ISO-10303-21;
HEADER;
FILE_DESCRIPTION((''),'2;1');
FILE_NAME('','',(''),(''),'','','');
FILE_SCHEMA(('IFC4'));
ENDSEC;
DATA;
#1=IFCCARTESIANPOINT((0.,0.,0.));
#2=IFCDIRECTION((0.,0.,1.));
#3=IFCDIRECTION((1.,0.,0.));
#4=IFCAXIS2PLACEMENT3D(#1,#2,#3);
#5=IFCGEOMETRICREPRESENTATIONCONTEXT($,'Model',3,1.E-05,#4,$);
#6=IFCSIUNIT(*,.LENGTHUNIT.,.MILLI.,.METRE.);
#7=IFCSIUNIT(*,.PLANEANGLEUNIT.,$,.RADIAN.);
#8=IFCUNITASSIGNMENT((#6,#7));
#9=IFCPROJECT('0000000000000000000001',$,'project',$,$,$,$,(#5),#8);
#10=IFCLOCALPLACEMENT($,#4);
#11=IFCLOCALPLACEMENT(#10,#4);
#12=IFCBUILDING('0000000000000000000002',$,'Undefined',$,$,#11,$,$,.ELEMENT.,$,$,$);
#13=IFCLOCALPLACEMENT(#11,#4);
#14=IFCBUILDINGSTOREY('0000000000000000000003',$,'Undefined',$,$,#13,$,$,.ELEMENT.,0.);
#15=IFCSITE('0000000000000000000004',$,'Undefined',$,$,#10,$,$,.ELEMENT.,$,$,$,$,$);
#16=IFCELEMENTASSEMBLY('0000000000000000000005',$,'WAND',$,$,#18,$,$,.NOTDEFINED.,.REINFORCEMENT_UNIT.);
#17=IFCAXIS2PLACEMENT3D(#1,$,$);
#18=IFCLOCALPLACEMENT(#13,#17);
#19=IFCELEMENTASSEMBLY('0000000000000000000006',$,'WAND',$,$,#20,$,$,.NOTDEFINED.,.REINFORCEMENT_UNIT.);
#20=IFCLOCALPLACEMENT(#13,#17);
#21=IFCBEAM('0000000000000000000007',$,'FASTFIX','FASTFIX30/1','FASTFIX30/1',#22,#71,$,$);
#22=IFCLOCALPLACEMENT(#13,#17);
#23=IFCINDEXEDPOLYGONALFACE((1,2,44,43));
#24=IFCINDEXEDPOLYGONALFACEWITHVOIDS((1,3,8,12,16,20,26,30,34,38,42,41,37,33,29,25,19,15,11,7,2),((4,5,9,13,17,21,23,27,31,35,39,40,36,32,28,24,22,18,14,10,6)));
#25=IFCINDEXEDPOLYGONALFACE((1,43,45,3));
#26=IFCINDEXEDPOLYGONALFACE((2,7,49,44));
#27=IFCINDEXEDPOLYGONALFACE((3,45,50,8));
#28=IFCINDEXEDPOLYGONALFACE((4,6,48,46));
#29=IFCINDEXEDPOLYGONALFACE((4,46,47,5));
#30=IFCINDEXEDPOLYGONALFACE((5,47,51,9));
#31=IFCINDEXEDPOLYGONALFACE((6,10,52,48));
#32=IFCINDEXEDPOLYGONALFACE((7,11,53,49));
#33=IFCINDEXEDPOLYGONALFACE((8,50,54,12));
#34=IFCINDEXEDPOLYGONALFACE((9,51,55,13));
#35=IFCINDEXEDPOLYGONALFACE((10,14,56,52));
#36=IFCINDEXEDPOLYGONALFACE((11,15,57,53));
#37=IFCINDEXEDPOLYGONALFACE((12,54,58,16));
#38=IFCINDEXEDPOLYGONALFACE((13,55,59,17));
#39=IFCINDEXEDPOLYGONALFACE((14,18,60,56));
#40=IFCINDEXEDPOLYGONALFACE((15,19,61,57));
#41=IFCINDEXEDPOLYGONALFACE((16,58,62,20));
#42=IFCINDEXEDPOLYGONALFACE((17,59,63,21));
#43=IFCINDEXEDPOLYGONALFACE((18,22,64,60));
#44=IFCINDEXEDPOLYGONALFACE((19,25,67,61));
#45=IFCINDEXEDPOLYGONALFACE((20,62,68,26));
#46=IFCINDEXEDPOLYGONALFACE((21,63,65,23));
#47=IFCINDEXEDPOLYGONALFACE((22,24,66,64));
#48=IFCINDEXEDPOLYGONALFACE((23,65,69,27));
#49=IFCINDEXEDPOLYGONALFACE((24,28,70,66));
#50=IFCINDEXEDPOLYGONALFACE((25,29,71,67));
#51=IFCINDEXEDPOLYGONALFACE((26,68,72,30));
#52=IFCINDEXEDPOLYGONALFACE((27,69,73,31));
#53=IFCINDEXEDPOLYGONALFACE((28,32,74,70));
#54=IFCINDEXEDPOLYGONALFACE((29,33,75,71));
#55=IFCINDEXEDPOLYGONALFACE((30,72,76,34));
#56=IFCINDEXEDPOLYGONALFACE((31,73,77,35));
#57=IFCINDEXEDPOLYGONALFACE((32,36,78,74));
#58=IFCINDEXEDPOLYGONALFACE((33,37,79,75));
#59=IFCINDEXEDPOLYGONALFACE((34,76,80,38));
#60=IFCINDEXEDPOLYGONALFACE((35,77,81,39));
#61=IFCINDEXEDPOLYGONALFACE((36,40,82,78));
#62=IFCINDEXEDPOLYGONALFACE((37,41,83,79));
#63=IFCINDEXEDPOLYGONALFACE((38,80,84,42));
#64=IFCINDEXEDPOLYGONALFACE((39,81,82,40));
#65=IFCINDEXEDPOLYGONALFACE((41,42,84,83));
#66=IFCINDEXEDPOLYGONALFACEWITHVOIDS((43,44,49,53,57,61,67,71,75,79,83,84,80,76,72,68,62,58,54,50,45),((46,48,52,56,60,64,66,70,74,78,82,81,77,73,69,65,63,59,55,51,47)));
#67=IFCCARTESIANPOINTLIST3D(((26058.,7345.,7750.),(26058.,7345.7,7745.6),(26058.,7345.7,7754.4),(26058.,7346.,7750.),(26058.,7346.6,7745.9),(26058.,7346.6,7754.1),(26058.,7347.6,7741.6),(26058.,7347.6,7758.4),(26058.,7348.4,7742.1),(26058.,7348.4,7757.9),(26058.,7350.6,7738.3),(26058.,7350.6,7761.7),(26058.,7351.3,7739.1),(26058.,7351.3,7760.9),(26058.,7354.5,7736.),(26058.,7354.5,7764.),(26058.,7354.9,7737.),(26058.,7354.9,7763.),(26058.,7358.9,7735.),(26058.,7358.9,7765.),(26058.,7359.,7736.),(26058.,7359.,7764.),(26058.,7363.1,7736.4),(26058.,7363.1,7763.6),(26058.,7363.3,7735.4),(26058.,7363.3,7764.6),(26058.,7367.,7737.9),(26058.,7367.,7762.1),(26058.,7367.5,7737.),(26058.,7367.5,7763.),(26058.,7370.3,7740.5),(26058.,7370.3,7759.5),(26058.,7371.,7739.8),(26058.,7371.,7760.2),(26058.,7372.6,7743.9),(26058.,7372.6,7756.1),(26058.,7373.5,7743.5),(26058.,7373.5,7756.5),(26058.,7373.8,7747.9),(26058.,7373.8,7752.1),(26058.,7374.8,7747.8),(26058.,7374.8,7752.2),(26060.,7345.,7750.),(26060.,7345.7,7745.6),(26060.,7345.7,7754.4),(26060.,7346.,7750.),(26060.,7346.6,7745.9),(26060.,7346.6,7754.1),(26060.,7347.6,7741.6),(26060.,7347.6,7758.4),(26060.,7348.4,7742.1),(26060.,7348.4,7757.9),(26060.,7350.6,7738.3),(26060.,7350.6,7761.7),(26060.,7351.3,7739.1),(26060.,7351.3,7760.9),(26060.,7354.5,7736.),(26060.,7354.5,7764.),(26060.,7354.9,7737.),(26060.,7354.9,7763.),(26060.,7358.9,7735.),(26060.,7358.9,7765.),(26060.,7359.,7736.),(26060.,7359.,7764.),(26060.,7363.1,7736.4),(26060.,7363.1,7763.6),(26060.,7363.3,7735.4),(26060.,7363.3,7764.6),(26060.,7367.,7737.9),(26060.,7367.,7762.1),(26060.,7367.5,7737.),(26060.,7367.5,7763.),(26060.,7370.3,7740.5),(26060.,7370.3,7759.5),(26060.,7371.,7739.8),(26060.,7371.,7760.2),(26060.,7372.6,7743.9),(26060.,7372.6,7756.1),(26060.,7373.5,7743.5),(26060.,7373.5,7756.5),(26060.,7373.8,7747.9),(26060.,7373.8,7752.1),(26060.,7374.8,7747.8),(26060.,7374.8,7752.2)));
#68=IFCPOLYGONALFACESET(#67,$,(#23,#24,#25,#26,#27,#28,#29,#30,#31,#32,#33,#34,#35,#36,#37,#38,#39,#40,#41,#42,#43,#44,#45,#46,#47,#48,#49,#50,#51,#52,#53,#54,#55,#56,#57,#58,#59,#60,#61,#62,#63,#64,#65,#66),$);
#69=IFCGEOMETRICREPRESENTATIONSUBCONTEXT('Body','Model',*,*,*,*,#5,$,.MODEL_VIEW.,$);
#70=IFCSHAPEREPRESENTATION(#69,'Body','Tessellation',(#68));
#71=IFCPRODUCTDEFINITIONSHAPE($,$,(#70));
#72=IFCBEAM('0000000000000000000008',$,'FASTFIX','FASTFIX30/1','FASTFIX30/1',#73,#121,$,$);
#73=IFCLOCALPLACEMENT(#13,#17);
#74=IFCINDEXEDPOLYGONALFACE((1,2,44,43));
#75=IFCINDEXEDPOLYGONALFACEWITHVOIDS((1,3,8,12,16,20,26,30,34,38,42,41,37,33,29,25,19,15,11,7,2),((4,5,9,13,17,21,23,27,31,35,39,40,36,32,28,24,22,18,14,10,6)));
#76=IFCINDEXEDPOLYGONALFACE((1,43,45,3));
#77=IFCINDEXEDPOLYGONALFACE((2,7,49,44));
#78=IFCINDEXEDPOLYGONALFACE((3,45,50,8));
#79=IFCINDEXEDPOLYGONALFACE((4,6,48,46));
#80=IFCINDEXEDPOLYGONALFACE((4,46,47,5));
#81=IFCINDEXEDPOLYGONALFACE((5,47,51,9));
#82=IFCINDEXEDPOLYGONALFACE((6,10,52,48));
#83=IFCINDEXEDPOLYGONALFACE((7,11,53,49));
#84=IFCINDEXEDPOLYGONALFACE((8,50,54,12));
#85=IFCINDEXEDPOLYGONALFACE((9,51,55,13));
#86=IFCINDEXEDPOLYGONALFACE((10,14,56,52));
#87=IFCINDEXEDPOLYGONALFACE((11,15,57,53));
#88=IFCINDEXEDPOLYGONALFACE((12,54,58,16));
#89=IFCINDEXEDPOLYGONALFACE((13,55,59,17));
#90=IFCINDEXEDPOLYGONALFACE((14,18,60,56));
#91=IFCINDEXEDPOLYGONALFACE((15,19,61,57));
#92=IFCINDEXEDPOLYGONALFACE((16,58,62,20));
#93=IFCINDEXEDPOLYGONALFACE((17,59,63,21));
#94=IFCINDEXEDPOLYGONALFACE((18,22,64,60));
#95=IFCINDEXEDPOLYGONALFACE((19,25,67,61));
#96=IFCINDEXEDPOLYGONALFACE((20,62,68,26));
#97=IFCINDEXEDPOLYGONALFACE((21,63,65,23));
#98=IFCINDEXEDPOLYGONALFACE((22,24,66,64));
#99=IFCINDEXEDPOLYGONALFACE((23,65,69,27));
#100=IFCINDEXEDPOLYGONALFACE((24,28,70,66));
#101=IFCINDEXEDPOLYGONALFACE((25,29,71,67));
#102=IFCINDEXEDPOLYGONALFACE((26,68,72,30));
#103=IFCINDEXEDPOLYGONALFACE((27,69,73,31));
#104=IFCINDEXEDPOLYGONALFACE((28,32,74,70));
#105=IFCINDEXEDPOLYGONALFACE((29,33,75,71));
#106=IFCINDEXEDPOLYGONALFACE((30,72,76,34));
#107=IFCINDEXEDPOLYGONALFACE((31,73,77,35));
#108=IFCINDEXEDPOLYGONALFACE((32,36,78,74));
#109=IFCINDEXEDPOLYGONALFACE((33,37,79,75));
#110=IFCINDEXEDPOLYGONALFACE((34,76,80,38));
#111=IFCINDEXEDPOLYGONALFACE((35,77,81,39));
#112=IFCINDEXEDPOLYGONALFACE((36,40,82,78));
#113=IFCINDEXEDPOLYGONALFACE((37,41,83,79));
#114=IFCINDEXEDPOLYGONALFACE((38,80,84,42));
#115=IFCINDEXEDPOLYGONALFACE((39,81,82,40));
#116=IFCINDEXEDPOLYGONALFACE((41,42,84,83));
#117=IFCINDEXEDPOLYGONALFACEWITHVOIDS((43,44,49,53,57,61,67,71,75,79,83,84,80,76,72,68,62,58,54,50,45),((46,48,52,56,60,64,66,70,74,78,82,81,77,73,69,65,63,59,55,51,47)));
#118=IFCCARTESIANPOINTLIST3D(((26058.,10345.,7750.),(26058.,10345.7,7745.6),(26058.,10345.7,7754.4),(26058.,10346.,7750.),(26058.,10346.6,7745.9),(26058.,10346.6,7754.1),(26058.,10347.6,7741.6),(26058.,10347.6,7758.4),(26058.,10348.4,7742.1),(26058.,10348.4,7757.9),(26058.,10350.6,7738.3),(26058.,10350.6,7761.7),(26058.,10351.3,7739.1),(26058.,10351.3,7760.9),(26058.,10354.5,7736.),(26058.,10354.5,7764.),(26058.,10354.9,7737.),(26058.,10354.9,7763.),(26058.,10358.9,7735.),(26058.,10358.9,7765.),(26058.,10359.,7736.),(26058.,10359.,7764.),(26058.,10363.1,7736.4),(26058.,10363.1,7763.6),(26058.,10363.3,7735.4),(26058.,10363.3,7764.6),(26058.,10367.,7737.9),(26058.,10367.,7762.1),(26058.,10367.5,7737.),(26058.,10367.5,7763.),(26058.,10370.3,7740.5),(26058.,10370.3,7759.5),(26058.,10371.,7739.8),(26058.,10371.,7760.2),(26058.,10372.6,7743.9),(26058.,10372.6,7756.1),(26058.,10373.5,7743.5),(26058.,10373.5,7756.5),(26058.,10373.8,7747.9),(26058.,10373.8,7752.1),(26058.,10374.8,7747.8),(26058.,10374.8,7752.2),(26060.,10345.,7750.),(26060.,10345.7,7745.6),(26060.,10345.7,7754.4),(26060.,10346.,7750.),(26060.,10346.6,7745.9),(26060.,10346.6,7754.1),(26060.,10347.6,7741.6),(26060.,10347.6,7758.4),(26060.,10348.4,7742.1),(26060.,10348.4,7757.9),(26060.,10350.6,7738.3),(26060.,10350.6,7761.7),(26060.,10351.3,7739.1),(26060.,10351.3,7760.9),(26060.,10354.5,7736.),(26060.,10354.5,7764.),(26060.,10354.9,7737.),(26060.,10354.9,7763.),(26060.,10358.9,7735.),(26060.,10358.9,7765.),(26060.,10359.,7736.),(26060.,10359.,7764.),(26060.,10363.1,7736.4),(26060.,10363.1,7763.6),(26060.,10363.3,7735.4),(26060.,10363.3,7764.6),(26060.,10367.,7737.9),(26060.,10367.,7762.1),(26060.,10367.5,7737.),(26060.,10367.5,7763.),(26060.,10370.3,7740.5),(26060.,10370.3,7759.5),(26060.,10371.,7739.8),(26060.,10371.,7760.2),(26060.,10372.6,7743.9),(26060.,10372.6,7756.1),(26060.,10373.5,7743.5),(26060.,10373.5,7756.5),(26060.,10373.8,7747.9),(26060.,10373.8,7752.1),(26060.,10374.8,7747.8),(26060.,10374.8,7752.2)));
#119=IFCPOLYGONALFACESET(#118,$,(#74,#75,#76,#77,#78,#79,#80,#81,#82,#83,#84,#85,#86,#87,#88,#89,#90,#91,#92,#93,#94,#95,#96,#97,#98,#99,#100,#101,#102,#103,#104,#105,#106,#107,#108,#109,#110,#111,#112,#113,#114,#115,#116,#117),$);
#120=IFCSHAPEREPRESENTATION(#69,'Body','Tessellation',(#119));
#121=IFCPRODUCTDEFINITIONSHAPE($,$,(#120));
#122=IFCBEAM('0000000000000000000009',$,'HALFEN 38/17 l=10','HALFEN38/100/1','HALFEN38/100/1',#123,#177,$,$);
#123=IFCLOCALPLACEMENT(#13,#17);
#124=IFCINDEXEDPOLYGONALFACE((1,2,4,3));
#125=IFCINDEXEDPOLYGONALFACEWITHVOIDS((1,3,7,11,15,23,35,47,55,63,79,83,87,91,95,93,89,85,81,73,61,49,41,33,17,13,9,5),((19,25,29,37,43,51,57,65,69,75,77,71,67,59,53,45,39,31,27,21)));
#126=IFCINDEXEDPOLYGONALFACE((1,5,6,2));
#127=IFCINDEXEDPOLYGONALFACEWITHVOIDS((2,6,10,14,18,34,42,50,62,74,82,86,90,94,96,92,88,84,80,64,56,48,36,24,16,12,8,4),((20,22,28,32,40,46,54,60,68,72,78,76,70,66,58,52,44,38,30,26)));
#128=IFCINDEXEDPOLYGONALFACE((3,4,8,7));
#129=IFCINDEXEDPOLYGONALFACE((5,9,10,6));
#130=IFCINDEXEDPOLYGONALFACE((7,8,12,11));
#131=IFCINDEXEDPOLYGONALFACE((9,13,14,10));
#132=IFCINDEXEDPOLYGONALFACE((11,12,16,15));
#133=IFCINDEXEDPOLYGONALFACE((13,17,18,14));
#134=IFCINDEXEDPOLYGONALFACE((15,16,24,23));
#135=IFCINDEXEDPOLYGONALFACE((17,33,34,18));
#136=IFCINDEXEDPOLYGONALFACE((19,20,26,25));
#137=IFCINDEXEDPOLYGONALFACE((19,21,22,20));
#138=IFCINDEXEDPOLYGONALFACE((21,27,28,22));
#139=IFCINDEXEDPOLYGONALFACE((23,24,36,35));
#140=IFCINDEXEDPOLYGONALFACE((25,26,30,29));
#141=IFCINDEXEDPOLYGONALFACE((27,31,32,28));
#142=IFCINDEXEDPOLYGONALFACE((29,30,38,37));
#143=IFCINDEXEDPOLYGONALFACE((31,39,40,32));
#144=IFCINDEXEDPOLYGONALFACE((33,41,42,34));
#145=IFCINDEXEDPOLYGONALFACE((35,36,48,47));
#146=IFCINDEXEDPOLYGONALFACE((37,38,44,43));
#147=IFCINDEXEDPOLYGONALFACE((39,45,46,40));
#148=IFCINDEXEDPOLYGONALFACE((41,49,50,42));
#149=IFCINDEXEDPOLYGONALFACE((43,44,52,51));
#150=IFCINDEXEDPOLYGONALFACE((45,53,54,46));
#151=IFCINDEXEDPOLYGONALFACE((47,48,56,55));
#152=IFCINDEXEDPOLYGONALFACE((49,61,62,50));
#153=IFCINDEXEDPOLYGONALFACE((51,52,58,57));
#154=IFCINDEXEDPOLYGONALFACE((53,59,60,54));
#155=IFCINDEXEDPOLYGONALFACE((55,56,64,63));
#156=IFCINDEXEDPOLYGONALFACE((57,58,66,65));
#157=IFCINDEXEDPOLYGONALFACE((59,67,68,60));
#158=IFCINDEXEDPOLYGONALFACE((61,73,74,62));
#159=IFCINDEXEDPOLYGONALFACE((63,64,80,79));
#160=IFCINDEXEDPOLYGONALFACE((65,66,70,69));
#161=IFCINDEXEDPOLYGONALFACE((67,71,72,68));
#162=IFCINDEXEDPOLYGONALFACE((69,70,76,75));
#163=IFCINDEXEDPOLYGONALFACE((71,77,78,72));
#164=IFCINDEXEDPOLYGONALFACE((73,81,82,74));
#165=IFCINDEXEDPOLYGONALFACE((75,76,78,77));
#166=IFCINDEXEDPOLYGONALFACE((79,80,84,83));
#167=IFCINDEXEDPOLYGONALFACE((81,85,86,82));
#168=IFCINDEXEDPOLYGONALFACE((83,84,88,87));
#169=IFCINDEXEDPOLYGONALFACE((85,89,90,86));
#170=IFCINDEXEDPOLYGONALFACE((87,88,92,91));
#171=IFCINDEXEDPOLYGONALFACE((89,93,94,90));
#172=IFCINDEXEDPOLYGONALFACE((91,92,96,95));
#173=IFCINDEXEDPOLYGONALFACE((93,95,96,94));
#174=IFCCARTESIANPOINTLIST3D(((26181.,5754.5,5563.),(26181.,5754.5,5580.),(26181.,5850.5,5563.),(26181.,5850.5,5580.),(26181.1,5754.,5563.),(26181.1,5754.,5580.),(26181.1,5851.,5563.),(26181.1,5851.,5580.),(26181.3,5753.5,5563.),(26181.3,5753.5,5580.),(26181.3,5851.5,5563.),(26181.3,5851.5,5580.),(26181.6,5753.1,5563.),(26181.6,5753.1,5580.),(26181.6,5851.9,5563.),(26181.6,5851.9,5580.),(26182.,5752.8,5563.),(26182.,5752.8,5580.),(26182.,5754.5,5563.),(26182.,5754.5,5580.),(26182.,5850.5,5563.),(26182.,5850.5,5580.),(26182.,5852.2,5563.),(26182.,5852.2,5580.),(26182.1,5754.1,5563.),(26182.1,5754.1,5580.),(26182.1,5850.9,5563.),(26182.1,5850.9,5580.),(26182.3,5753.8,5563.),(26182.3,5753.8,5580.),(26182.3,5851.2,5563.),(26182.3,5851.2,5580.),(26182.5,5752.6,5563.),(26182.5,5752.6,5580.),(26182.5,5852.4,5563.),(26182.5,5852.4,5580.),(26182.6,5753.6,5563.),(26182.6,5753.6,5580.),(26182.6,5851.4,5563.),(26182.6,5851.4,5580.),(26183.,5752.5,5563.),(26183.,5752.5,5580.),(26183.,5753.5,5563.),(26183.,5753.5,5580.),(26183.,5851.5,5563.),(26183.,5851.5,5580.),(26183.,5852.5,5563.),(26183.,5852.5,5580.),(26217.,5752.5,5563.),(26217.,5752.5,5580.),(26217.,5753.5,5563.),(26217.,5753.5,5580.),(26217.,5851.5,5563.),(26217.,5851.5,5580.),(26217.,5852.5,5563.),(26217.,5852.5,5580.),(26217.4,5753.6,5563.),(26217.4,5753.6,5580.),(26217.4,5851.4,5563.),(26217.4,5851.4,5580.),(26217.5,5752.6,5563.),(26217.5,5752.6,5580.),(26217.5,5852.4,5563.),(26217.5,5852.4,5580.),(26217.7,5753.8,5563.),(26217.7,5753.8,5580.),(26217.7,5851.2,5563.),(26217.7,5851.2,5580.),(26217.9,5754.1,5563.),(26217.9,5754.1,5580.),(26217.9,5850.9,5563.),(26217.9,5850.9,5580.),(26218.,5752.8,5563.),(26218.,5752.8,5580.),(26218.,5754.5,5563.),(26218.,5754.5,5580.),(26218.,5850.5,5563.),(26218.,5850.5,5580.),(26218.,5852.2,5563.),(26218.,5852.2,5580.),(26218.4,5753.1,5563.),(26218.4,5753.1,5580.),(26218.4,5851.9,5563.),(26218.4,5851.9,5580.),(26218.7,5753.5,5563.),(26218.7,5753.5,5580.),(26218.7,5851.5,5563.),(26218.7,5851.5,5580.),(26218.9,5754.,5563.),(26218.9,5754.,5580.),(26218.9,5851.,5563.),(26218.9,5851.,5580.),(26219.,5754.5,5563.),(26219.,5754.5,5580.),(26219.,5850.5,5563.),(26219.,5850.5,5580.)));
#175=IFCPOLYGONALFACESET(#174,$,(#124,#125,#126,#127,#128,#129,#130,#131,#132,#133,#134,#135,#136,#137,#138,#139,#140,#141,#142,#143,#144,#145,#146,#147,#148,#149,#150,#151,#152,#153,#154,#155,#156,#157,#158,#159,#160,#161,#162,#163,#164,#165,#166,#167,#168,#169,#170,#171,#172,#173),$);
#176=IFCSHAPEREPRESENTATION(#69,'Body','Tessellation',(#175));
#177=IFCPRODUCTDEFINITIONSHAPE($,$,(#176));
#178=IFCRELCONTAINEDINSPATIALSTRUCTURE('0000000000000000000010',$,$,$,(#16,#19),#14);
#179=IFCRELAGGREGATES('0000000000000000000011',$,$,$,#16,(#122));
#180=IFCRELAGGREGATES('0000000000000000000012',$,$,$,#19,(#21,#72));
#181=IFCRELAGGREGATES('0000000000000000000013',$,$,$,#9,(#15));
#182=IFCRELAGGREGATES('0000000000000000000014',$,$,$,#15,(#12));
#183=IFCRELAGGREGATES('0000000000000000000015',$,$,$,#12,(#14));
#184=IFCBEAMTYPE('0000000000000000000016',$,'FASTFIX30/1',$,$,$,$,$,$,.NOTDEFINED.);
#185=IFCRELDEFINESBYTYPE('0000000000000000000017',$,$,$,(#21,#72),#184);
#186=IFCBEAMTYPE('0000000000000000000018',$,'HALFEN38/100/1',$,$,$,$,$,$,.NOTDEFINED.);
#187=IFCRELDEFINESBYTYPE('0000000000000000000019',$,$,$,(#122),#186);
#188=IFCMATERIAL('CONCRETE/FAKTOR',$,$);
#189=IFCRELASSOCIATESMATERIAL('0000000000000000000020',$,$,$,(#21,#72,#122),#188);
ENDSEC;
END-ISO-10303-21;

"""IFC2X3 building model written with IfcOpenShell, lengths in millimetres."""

from ifc_helpers import new_model, si_unit, frame, frame_2d, origin_with_axes, place, context, subcontext, project, spatial, hollow_rectangle, hollow_circle, extrude, material, type_object, element, aggregate, save


model = new_model("IFC2X3")

# Units and contexts
model_context = context("Model", 3, precision=1e-05, world=origin_with_axes())
body_context = subcontext(model_context, "Body", "Model", "MODEL_VIEW")
ifc_project = project(units=[si_unit("LENGTHUNIT", "METRE", prefix="MILLI"), si_unit("PLANEANGLEUNIT", "RADIAN")], contexts=[model_context])

# Site, building, storey
site_placement = place(None, origin_with_axes())
site = spatial("IfcSite", under=ifc_project, at=site_placement, Name="Undefined", CompositionType="ELEMENT")
building_placement = place(site_placement, origin_with_axes())
building = spatial("IfcBuilding", under=site, at=building_placement, Name="Undefined", CompositionType="ELEMENT")
storey_placement = place(building_placement, origin_with_axes())
storey = spatial("IfcBuildingStorey", under=building, at=storey_placement, Name="Undefined", CompositionType="ELEMENT", Elevation=0.0)

# Element assembly
assembly_1_placement = place(storey_placement, origin_with_axes())
assembly_1 = element("IfcElementAssembly", 1, at=assembly_1_placement, inside=storey, Name="WAND", AssemblyPlace="NOTDEFINED", PredefinedType="REINFORCEMENT_UNIT")
ifc_material_1 = material(Name="CONCRETE/FAKTOR")

# Element assembly, beams
assembly_2_placement = place(storey_placement, origin_with_axes())
assembly_2 = element("IfcElementAssembly", 2, at=assembly_2_placement, inside=storey, Name="WAND", AssemblyPlace="NOTDEFINED", PredefinedType="REINFORCEMENT_UNIT")
beam_type_1 = type_object("IfcBeamType", Name="FASTFIX30/1", PredefinedType="NOTDEFINED")
beam_1_placement = place(assembly_2_placement, frame((26060.0, 7360.0, 7750.0), z_axis=(0.0, 0.0, -1.0), x_axis=(-1.0, 0.0, 0.0)))
beam_1 = element("IfcBeam", 3, at=beam_1_placement, type_object=beam_type_1, material=ifc_material_1, Name="FASTFIX", Description="FASTFIX30/1", ObjectType="FASTFIX30/1", context=body_context, shape_type="SweptSolid", body=[
    extrude(hollow_circle(Radius=15.0, WallThickness=1.0, at=frame_2d((0.0, 0.0), x_axis=(1.0, 0.0))), frame((2.0, 0.0, 0.0), z_axis=(-1.0, 0.0, 0.0), x_axis=(0.0, -1.0, 0.0)), (0.0, 0.0, 1.0), 2.0),
])
beam_2_placement = place(assembly_2_placement, frame((26060.0, 10360.0, 7750.0), z_axis=(0.0, 0.0, -1.0), x_axis=(-1.0, 0.0, 0.0)))
beam_2 = element("IfcBeam", 4, at=beam_2_placement, type_object=beam_type_1, material=ifc_material_1, Name="FASTFIX", Description="FASTFIX30/1", ObjectType="FASTFIX30/1", context=body_context, shape_type="SweptSolid", body=[
    extrude(hollow_circle(Radius=15.0, WallThickness=1.0, at=frame_2d((0.0, 0.0), x_axis=(1.0, 0.0))), frame((2.0, 0.0, 0.0), z_axis=(-1.0, 0.0, 0.0), x_axis=(0.0, -1.0, 0.0)), (0.0, 0.0, 1.0), 2.0),
])

# Beam
beam_type_2 = type_object("IfcBeamType", Name="HALFEN38/100/1", PredefinedType="NOTDEFINED")
beam_3_placement = place(assembly_1_placement, frame((26200.0, 5802.5, 5580.0), z_axis=(-1.0, 0.0, 0.0), x_axis=(0.0, 0.0, -1.0)))
beam_3 = element("IfcBeam", 5, at=beam_3_placement, type_object=beam_type_2, material=ifc_material_1, Name="HALFEN 38/17 l=10", Description="HALFEN38/100/1", ObjectType="HALFEN38/100/1", context=body_context, shape_type="SweptSolid", body=[
    extrude(hollow_rectangle(XDim=100.0, YDim=38.0, WallThickness=1.0, InnerFilletRadius=1.0, OuterFilletRadius=2.0, at=frame_2d((0.0, 0.0), x_axis=(1.0, 0.0))), frame((17.0, 0.0, 0.0), z_axis=(-1.0, 0.0, 0.0), x_axis=(0.0, -1.0, 0.0)), (0.0, 0.0, 1.0), 17.0),
])
aggregate(assembly_1, [beam_3])

aggregate(assembly_2, [beam_1, beam_2])

save(model, "model.ifc")
